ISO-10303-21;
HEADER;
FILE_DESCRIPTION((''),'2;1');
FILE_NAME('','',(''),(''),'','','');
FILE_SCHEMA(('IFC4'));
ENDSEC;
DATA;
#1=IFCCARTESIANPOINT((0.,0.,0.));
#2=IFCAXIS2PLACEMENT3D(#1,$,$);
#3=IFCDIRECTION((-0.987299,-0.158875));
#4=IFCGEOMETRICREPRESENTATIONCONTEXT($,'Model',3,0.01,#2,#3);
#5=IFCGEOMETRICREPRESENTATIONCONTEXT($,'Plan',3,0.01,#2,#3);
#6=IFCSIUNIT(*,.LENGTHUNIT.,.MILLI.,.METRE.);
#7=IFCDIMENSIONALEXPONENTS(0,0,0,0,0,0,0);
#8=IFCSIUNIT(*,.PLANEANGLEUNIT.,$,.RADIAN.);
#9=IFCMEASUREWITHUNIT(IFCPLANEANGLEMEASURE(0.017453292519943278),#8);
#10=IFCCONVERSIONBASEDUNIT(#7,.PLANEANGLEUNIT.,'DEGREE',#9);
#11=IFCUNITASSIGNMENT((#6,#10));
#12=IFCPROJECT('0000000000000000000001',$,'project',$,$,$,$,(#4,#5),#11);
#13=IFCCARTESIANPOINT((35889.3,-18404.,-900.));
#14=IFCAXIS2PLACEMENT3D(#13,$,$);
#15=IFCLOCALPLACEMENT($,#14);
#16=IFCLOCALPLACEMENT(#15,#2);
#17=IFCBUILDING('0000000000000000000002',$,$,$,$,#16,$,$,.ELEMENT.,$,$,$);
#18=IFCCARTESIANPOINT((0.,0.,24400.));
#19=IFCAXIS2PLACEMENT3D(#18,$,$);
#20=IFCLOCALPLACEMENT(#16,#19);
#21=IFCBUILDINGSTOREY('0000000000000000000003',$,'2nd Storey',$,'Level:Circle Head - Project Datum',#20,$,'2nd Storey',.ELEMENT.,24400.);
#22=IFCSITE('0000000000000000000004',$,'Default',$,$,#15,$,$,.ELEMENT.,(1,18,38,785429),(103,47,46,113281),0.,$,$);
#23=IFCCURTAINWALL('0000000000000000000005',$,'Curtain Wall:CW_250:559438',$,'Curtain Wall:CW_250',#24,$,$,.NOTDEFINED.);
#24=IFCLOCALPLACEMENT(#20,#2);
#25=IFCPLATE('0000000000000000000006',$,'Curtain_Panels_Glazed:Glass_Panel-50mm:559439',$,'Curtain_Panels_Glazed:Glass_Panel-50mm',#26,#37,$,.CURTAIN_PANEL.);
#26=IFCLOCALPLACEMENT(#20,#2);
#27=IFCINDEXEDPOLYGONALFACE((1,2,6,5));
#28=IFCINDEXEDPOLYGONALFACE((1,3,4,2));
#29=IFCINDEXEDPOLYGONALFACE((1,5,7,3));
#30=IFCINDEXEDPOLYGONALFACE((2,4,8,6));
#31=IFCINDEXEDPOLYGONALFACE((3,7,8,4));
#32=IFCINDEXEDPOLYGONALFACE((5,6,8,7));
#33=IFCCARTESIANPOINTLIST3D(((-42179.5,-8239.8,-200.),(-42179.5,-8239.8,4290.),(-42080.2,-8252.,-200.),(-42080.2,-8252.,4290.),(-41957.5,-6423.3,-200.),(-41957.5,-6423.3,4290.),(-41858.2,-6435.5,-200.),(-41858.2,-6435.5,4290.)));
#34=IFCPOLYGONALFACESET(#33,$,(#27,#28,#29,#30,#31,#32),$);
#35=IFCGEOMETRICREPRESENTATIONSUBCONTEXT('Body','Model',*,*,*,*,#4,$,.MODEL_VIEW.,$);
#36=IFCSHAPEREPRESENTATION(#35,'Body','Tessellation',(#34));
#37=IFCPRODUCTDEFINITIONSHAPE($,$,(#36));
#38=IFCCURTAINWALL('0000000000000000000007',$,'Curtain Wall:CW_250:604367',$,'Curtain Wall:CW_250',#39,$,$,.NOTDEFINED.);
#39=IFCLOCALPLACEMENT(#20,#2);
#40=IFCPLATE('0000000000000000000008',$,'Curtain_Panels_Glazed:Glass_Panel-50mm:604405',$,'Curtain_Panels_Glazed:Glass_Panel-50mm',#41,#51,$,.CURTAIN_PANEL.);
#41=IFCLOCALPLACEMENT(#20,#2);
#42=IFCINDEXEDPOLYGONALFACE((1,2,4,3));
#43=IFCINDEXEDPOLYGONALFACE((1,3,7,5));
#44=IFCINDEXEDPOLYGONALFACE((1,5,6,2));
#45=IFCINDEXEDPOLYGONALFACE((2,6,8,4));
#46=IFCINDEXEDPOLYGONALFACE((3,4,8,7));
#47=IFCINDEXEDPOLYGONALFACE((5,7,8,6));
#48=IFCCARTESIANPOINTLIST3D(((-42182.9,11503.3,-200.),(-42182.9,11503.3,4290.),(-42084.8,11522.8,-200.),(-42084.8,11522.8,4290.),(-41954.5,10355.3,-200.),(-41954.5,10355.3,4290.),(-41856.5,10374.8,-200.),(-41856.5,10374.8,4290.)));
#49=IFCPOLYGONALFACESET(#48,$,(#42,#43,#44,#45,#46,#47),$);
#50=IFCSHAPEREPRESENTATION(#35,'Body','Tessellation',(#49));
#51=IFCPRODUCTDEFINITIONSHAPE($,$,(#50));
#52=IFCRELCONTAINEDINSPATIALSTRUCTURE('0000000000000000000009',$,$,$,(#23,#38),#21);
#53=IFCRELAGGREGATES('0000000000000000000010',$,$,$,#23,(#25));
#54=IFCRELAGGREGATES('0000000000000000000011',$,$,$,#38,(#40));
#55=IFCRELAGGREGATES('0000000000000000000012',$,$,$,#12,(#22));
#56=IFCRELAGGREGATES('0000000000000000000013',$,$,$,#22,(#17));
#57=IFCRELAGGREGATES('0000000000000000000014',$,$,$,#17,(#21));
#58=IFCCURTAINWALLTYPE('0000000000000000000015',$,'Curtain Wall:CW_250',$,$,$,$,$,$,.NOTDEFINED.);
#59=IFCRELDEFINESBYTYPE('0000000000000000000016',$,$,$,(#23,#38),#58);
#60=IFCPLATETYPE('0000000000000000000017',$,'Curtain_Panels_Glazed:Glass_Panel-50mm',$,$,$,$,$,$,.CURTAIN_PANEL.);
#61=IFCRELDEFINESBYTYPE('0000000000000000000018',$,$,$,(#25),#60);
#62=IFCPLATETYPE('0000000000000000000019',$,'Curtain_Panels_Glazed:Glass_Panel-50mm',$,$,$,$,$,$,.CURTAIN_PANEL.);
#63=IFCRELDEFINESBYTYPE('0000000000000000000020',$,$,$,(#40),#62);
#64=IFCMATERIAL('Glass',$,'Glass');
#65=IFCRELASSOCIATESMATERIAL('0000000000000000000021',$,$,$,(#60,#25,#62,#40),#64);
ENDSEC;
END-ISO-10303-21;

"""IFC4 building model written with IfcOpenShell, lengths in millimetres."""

from ifc_helpers import new_model, entity, si_unit, converted_unit, direction, frame, origin, place, context, subcontext, project, spatial, indexed_curve, outline, extrude, source, transform, mapped, material, type_object, type_shapes, element, aggregate, save


model = new_model("IFC4")

# Units and contexts
model_context = context("Model", 3, precision=0.01, world=origin(), true_north=direction((-0.987299, -0.158875)))
plan_context = context("Plan", 3, precision=0.01, world=origin(), true_north=direction((-0.987299, -0.158875)))
body_context = subcontext(model_context, "Body", "Model", "MODEL_VIEW")
ifc_project = project(units=[si_unit("LENGTHUNIT", "METRE", prefix="MILLI"), converted_unit("PLANEANGLEUNIT", "DEGREE", entity("IfcPlaneAngleMeasure", 0.017453292519943278), si_unit("PLANEANGLEUNIT", "RADIAN"), dimensions=[0, 0, 0, 0, 0, 0, 0])], contexts=[model_context, plan_context])

# Site, building, storey
site_placement = place(None, frame((35889.3, -18404.0, -900.0)))
site = spatial("IfcSite", under=ifc_project, at=site_placement, Name="Default", CompositionType="ELEMENT", RefLatitude=(1, 18, 38, 785429), RefLongitude=(103, 47, 46, 113281), RefElevation=0.0)
building_placement = place(site_placement, origin())
building = spatial("IfcBuilding", under=site, at=building_placement, CompositionType="ELEMENT")
storey_placement = place(building_placement, frame((0.0, 0.0, 24400.0)))
storey = spatial("IfcBuildingStorey", under=building, at=storey_placement, Name="2nd Storey", ObjectType="Level:Circle Head - Project Datum", LongName="2nd Storey", CompositionType="ELEMENT", Elevation=24400.0)

# Shared definitions
curtain_wall_type = type_object("IfcCurtainWallType", Name="Curtain Wall:CW_250", PredefinedType="NOTDEFINED")

# Curtain wall
curtain_wall_1_placement = place(storey_placement, frame((0.0, 0.0, -24400.0)))
curtain_wall_1 = element("IfcCurtainWall", 1, at=curtain_wall_1_placement, inside=storey, type_object=curtain_wall_type, Name="Curtain Wall:CW_250:559438", ObjectType="Curtain Wall:CW_250", PredefinedType="NOTDEFINED")

# Plate
ifc_material_1 = material(Name="Glass", Category="Glass")
plate_type_1 = type_object("IfcPlateType", Name="Curtain_Panels_Glazed:Glass_Panel-50mm", PredefinedType="CURTAIN_PANEL", material=ifc_material_1)
shared_shape_1 = source(origin(), body_context, "Body", "SweptSolid", [
    extrude(outline(indexed_curve([(-915.0, -50.0), (915.0, -50.0), (915.0, 50.0), (-915.0, 50.0), (-915.0, -50.0)], self_intersect=False)), frame((0.0, -200.0, 0.0), z_axis=(0.0, 0.0, 1.0), x_axis=(-1.0, 0.0, 0.0)), (0.0, 0.0, 1.0), 4490.0),
])
type_shapes(plate_type_1, [shared_shape_1])
plate_1_placement = place(curtain_wall_1_placement, frame((-41820.3, -7361.9, 24200.0), z_axis=(0.0, 0.0, 1.0), x_axis=(-0.121316, -0.992614, 0.0)))
plate_1 = element("IfcPlate", 2, at=plate_1_placement, type_object=plate_type_1, material=ifc_material_1, Name="Curtain_Panels_Glazed:Glass_Panel-50mm:559439", ObjectType="Curtain_Panels_Glazed:Glass_Panel-50mm", PredefinedType="CURTAIN_PANEL", context=body_context, shape_type="MappedRepresentation", body=[
    mapped(shared_shape_1, transform((0.0, 0.0, 0.0), scale=1.0)),
])
aggregate(curtain_wall_1, [plate_1])

# Curtain wall, plate
curtain_wall_2_placement = place(storey_placement, frame((0.0, 0.0, -24400.0)))
curtain_wall_2 = element("IfcCurtainWall", 3, at=curtain_wall_2_placement, inside=storey, type_object=curtain_wall_type, Name="Curtain Wall:CW_250:604367", ObjectType="Curtain Wall:CW_250", PredefinedType="NOTDEFINED")
plate_type_2 = type_object("IfcPlateType", Name="Curtain_Panels_Glazed:Glass_Panel-50mm", PredefinedType="CURTAIN_PANEL", material=ifc_material_1)
shared_shape_2 = source(origin(), body_context, "Body", "SweptSolid", [
    extrude(outline(indexed_curve([(-585.3, -50.0), (585.3, -50.0), (585.3, 50.0), (-585.3, 50.0), (-585.3, -50.0)], self_intersect=False)), frame((0.0, -200.0, 0.0), z_axis=(0.0, 0.0, 1.0), x_axis=(-1.0, 0.0, 0.0)), (0.0, 0.0, 1.0), 4490.0),
])
type_shapes(plate_type_2, [shared_shape_2])
plate_2_placement = place(curtain_wall_2_placement, frame((-41823.5, 10978.1, 24200.0), z_axis=(0.0, 0.0, 1.0), x_axis=(0.19509, -0.980785, 0.0)))
plate_2 = element("IfcPlate", 4, at=plate_2_placement, type_object=plate_type_2, material=ifc_material_1, Name="Curtain_Panels_Glazed:Glass_Panel-50mm:604405", ObjectType="Curtain_Panels_Glazed:Glass_Panel-50mm", PredefinedType="CURTAIN_PANEL", context=body_context, shape_type="MappedRepresentation", body=[
    mapped(shared_shape_2, transform((0.0, 0.0, 0.0), scale=1.0)),
])
aggregate(curtain_wall_2, [plate_2])

save(model, "model.ifc")
